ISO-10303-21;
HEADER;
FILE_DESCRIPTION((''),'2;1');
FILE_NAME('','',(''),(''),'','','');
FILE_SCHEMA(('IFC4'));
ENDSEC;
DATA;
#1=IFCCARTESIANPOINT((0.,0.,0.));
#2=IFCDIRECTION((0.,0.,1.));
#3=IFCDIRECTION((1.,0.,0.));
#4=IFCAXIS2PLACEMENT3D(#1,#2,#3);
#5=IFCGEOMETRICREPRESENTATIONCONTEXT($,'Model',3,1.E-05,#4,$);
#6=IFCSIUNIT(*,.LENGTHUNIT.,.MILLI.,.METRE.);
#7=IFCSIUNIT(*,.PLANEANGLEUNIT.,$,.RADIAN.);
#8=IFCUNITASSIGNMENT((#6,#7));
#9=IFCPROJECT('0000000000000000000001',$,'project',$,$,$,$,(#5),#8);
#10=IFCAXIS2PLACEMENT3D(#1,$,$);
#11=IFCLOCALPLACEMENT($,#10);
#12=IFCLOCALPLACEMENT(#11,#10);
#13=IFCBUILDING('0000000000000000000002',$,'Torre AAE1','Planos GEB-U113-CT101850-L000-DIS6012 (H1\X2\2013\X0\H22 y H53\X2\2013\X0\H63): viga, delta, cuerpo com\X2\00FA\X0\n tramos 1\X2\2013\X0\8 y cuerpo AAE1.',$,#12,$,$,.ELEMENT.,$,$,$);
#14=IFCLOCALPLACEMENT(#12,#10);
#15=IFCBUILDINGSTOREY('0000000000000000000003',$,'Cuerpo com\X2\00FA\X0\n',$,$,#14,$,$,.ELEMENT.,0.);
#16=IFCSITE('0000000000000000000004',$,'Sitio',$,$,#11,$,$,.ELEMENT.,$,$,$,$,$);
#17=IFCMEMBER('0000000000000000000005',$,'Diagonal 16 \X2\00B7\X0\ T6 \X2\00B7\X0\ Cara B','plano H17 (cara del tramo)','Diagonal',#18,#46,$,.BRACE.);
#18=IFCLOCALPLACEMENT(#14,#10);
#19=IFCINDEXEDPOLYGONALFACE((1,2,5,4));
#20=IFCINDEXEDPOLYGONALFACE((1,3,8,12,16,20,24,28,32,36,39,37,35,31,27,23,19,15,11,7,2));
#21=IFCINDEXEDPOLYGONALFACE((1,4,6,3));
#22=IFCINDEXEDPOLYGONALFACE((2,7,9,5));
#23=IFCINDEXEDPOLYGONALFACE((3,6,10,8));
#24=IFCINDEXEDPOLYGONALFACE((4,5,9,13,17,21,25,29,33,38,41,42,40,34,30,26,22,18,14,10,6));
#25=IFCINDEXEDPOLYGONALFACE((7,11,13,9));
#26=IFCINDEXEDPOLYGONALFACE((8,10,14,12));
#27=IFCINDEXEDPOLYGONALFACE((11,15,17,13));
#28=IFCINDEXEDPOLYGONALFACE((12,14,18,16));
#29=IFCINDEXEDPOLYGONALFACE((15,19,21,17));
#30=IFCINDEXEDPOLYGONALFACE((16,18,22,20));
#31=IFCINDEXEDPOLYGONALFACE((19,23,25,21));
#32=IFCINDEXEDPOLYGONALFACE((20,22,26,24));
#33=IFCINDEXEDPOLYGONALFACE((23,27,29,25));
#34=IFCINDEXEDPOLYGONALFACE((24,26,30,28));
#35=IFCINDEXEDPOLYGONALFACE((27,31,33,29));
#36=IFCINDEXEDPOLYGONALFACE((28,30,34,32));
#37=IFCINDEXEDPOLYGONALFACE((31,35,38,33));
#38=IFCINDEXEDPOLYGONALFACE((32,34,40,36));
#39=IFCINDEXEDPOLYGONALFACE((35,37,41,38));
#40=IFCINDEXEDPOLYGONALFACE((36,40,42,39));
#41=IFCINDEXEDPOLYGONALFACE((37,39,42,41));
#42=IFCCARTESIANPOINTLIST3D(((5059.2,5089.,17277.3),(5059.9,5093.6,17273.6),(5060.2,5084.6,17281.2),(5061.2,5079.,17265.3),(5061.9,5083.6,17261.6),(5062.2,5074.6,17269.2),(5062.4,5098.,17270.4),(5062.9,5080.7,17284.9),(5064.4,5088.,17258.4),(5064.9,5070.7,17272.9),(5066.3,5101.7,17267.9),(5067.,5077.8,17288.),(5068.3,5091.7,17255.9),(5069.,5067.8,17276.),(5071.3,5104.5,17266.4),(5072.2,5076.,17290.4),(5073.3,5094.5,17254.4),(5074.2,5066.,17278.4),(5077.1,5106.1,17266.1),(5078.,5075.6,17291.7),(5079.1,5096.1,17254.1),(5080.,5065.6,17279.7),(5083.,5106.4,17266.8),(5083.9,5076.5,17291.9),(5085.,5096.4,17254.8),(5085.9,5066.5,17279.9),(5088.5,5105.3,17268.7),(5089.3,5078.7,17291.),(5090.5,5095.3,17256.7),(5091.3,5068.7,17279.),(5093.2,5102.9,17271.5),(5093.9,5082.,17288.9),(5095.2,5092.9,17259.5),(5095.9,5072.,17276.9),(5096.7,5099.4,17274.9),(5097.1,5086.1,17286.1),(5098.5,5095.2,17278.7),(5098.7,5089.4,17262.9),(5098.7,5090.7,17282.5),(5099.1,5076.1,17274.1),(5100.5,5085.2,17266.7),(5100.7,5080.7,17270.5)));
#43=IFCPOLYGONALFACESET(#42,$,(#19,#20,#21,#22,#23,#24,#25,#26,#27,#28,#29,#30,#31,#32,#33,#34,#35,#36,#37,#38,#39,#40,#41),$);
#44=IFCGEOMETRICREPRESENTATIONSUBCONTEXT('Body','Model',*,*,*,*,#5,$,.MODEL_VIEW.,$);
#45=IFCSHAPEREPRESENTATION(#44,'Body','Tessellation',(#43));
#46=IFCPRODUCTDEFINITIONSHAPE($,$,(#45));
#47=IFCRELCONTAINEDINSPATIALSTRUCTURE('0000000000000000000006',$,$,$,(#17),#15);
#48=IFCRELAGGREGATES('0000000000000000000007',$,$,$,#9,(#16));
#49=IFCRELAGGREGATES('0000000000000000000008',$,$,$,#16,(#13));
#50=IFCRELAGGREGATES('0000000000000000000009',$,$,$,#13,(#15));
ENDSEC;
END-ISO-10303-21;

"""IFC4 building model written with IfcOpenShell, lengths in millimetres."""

from ifc_helpers import new_model, si_unit, frame, origin, origin_with_axes, place, context, subcontext, project, spatial, circle, extrude, element, save


model = new_model("IFC4")

# Units and contexts
model_context = context("Model", 3, precision=1e-05, world=origin_with_axes())
body_context = subcontext(model_context, "Body", "Model", "MODEL_VIEW")
ifc_project = project(units=[si_unit("LENGTHUNIT", "METRE", prefix="MILLI"), si_unit("PLANEANGLEUNIT", "RADIAN")], contexts=[model_context])

# Site, building, storey
site_placement = place(None, origin())
site = spatial("IfcSite", under=ifc_project, at=site_placement, Name="Sitio", CompositionType="ELEMENT")
building_placement = place(site_placement, origin())
building = spatial("IfcBuilding", under=site, at=building_placement, Name="Torre AAE1", Description="Planos GEB-U113-CT101850-L000-DIS6012 (H1–H22 y H53–H63): viga, delta, cuerpo común tramos 1–8 y cuerpo AAE1.", CompositionType="ELEMENT")
storey_placement = place(building_placement, origin())
storey = spatial("IfcBuildingStorey", under=building, at=storey_placement, Name="Cuerpo común", CompositionType="ELEMENT", Elevation=0.0)

# Member
for number, where, z_axis, x_axis, name in (
    (1, (5079.0, 5091.0, 17279.0), (0.127, -0.635001, -0.762001), (-0.806261, -0.513563, 0.293592), "Diagonal 16 · T6 · Cara B"),
):
    element("IfcMember", number, at=place(storey_placement, frame(where, z_axis=z_axis, x_axis=x_axis)), inside=storey, Name=name, Description="plano H17 (cara del tramo)", ObjectType="Diagonal", PredefinedType="BRACE", context=body_context, shape_type="SweptSolid", body=[
        extrude(circle(Radius=20.0), None, (0.0, 0.0, 1.0), 15.7),
    ])

save(model, "model.ifc")
